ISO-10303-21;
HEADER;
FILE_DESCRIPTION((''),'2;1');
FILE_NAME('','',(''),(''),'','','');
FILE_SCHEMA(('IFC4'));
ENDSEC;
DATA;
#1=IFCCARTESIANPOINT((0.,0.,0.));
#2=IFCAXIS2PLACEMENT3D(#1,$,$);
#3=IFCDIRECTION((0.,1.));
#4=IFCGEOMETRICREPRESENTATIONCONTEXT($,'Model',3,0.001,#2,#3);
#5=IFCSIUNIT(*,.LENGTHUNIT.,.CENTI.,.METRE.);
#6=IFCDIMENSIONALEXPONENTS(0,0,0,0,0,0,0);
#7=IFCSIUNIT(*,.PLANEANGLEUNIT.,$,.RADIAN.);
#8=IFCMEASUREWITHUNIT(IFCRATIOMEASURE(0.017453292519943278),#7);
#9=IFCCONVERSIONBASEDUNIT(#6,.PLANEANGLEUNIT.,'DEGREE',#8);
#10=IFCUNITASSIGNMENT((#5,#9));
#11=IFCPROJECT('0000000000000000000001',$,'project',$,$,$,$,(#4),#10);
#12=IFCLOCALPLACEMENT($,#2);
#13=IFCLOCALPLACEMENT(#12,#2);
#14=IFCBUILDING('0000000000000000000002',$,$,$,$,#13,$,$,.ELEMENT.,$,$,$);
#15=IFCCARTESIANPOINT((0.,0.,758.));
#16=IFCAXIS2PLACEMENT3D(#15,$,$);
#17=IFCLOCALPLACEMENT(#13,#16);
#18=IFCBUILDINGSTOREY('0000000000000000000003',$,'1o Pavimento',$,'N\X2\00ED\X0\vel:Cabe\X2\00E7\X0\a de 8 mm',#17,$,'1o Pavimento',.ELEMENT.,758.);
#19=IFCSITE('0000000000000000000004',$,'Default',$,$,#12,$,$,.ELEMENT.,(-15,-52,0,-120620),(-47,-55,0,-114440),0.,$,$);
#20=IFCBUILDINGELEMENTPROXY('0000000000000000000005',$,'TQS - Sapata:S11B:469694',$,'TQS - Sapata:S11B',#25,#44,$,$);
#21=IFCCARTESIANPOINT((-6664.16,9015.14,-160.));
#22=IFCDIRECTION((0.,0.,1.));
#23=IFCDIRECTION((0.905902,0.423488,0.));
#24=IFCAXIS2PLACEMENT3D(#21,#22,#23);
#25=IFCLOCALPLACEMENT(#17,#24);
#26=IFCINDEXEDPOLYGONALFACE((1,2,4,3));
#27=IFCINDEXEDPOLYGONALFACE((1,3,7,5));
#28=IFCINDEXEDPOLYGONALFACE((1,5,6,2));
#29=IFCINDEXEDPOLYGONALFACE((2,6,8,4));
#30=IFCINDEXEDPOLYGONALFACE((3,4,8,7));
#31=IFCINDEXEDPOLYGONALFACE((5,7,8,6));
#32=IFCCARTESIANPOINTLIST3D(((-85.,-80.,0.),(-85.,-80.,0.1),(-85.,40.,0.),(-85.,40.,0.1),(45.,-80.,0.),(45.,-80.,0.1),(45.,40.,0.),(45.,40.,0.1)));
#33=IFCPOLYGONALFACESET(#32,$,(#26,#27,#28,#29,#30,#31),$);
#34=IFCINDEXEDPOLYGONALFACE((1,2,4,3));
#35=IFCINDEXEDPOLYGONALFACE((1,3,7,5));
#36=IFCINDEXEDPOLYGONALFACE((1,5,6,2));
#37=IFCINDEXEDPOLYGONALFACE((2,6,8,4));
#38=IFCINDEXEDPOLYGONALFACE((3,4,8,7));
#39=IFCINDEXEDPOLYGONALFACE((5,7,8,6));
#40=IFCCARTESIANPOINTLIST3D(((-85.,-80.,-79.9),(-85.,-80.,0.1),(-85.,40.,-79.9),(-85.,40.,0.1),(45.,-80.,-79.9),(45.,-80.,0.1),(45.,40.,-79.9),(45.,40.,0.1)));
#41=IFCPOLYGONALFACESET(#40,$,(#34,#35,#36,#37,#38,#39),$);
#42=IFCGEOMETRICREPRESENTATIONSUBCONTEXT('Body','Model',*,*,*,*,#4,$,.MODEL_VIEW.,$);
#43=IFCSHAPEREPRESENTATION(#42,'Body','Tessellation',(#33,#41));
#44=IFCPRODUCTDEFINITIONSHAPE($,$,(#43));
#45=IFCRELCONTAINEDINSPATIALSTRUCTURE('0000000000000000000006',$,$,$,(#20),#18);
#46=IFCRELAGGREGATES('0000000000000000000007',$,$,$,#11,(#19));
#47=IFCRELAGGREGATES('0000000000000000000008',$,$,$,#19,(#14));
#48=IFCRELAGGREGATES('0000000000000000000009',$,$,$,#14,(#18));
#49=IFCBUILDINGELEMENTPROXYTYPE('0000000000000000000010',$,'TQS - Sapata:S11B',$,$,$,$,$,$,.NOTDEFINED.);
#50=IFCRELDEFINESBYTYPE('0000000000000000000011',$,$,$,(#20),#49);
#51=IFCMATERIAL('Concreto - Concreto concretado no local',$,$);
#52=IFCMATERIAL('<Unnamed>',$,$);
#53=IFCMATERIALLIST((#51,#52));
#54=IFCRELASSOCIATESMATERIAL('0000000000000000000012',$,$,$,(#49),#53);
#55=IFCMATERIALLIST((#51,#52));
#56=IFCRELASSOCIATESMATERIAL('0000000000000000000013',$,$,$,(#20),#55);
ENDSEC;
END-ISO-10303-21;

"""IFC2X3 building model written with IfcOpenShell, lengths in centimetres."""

from ifc_helpers import new_model, entity, si_unit, converted_unit, direction, frame, frame_2d, origin, origin_2d_with_axis, place, context, subcontext, project, spatial, rectangle, extrude, source, transform, mapped, material, material_list, type_object, type_shapes, element, save


model = new_model("IFC2X3")

# Units and contexts
model_context = context("Model", 3, precision=0.001, world=origin(), true_north=direction((0.0, 1.0)))
body_context = subcontext(model_context, "Body", "Model", "MODEL_VIEW")
ifc_project = project(units=[si_unit("LENGTHUNIT", "METRE", prefix="CENTI"), converted_unit("PLANEANGLEUNIT", "DEGREE", entity("IfcRatioMeasure", 0.017453292519943278), si_unit("PLANEANGLEUNIT", "RADIAN"), dimensions=[0, 0, 0, 0, 0, 0, 0])], contexts=[model_context])

# Site, building, storey
site_placement = place(None, origin())
site = spatial("IfcSite", under=ifc_project, at=site_placement, Name="Default", CompositionType="ELEMENT", RefLatitude=(-15, -52, 0, -120620), RefLongitude=(-47, -55, 0, -114440), RefElevation=0.0)
building_placement = place(site_placement, origin())
building = spatial("IfcBuilding", under=site, at=building_placement, CompositionType="ELEMENT")
storey_placement = place(building_placement, frame((0.0, 0.0, 758.0)))
storey = spatial("IfcBuildingStorey", under=building, at=storey_placement, Name="1o Pavimento", ObjectType="Nível:Cabeça de 8 mm", LongName="1o Pavimento", CompositionType="ELEMENT", Elevation=758.0)

# Building element proxy
ifc_material_1 = material(Name="Concreto - Concreto concretado no local")
ifc_material_2 = material(Name="<Unnamed>")
ifc_material_list_1 = material_list([ifc_material_1, ifc_material_2])
ifc_material_list_2 = material_list([ifc_material_1, ifc_material_2])
building_element_proxy_type_1 = type_object("IfcBuildingElementProxyType", Name="TQS - Sapata:S11B", PredefinedType="NOTDEFINED", material=ifc_material_list_2)
shared_shape_1 = source(origin(), body_context, "Body", "SweptSolid", [
    extrude(rectangle(XDim=130.0, YDim=120.0, at=frame_2d((0.0, 0.0), x_axis=(1.0, 0.0))), frame((-20.0, -20.0, 0.0), z_axis=(0.0, 0.0, 1.0), x_axis=(-1.0, 0.0, 0.0)), (0.0, 0.0, 1.0), 0.1),
    extrude(rectangle(XDim=130.0, YDim=120.0, at=origin_2d_with_axis()), frame((-20.0, -20.0, -79.9), z_axis=(0.0, 0.0, 1.0), x_axis=(-1.0, 0.0, 0.0)), (0.0, 0.0, 1.0), 80.0),
])
type_shapes(building_element_proxy_type_1, [shared_shape_1])
proxy_1_placement = place(storey_placement, frame((-6664.16, 9015.14, -160.0), z_axis=(0.0, 0.0, 1.0), x_axis=(0.905902, 0.423488, 0.0)))
element("IfcBuildingElementProxy", 1, at=proxy_1_placement, inside=storey, type_object=building_element_proxy_type_1, material=ifc_material_list_1, Name="TQS - Sapata:S11B:469694", ObjectType="TQS - Sapata:S11B", context=body_context, shape_type="MappedRepresentation", body=[
    mapped(shared_shape_1, transform((0.0, 0.0, 0.0), scale=1.0)),
])

save(model, "model.ifc")
